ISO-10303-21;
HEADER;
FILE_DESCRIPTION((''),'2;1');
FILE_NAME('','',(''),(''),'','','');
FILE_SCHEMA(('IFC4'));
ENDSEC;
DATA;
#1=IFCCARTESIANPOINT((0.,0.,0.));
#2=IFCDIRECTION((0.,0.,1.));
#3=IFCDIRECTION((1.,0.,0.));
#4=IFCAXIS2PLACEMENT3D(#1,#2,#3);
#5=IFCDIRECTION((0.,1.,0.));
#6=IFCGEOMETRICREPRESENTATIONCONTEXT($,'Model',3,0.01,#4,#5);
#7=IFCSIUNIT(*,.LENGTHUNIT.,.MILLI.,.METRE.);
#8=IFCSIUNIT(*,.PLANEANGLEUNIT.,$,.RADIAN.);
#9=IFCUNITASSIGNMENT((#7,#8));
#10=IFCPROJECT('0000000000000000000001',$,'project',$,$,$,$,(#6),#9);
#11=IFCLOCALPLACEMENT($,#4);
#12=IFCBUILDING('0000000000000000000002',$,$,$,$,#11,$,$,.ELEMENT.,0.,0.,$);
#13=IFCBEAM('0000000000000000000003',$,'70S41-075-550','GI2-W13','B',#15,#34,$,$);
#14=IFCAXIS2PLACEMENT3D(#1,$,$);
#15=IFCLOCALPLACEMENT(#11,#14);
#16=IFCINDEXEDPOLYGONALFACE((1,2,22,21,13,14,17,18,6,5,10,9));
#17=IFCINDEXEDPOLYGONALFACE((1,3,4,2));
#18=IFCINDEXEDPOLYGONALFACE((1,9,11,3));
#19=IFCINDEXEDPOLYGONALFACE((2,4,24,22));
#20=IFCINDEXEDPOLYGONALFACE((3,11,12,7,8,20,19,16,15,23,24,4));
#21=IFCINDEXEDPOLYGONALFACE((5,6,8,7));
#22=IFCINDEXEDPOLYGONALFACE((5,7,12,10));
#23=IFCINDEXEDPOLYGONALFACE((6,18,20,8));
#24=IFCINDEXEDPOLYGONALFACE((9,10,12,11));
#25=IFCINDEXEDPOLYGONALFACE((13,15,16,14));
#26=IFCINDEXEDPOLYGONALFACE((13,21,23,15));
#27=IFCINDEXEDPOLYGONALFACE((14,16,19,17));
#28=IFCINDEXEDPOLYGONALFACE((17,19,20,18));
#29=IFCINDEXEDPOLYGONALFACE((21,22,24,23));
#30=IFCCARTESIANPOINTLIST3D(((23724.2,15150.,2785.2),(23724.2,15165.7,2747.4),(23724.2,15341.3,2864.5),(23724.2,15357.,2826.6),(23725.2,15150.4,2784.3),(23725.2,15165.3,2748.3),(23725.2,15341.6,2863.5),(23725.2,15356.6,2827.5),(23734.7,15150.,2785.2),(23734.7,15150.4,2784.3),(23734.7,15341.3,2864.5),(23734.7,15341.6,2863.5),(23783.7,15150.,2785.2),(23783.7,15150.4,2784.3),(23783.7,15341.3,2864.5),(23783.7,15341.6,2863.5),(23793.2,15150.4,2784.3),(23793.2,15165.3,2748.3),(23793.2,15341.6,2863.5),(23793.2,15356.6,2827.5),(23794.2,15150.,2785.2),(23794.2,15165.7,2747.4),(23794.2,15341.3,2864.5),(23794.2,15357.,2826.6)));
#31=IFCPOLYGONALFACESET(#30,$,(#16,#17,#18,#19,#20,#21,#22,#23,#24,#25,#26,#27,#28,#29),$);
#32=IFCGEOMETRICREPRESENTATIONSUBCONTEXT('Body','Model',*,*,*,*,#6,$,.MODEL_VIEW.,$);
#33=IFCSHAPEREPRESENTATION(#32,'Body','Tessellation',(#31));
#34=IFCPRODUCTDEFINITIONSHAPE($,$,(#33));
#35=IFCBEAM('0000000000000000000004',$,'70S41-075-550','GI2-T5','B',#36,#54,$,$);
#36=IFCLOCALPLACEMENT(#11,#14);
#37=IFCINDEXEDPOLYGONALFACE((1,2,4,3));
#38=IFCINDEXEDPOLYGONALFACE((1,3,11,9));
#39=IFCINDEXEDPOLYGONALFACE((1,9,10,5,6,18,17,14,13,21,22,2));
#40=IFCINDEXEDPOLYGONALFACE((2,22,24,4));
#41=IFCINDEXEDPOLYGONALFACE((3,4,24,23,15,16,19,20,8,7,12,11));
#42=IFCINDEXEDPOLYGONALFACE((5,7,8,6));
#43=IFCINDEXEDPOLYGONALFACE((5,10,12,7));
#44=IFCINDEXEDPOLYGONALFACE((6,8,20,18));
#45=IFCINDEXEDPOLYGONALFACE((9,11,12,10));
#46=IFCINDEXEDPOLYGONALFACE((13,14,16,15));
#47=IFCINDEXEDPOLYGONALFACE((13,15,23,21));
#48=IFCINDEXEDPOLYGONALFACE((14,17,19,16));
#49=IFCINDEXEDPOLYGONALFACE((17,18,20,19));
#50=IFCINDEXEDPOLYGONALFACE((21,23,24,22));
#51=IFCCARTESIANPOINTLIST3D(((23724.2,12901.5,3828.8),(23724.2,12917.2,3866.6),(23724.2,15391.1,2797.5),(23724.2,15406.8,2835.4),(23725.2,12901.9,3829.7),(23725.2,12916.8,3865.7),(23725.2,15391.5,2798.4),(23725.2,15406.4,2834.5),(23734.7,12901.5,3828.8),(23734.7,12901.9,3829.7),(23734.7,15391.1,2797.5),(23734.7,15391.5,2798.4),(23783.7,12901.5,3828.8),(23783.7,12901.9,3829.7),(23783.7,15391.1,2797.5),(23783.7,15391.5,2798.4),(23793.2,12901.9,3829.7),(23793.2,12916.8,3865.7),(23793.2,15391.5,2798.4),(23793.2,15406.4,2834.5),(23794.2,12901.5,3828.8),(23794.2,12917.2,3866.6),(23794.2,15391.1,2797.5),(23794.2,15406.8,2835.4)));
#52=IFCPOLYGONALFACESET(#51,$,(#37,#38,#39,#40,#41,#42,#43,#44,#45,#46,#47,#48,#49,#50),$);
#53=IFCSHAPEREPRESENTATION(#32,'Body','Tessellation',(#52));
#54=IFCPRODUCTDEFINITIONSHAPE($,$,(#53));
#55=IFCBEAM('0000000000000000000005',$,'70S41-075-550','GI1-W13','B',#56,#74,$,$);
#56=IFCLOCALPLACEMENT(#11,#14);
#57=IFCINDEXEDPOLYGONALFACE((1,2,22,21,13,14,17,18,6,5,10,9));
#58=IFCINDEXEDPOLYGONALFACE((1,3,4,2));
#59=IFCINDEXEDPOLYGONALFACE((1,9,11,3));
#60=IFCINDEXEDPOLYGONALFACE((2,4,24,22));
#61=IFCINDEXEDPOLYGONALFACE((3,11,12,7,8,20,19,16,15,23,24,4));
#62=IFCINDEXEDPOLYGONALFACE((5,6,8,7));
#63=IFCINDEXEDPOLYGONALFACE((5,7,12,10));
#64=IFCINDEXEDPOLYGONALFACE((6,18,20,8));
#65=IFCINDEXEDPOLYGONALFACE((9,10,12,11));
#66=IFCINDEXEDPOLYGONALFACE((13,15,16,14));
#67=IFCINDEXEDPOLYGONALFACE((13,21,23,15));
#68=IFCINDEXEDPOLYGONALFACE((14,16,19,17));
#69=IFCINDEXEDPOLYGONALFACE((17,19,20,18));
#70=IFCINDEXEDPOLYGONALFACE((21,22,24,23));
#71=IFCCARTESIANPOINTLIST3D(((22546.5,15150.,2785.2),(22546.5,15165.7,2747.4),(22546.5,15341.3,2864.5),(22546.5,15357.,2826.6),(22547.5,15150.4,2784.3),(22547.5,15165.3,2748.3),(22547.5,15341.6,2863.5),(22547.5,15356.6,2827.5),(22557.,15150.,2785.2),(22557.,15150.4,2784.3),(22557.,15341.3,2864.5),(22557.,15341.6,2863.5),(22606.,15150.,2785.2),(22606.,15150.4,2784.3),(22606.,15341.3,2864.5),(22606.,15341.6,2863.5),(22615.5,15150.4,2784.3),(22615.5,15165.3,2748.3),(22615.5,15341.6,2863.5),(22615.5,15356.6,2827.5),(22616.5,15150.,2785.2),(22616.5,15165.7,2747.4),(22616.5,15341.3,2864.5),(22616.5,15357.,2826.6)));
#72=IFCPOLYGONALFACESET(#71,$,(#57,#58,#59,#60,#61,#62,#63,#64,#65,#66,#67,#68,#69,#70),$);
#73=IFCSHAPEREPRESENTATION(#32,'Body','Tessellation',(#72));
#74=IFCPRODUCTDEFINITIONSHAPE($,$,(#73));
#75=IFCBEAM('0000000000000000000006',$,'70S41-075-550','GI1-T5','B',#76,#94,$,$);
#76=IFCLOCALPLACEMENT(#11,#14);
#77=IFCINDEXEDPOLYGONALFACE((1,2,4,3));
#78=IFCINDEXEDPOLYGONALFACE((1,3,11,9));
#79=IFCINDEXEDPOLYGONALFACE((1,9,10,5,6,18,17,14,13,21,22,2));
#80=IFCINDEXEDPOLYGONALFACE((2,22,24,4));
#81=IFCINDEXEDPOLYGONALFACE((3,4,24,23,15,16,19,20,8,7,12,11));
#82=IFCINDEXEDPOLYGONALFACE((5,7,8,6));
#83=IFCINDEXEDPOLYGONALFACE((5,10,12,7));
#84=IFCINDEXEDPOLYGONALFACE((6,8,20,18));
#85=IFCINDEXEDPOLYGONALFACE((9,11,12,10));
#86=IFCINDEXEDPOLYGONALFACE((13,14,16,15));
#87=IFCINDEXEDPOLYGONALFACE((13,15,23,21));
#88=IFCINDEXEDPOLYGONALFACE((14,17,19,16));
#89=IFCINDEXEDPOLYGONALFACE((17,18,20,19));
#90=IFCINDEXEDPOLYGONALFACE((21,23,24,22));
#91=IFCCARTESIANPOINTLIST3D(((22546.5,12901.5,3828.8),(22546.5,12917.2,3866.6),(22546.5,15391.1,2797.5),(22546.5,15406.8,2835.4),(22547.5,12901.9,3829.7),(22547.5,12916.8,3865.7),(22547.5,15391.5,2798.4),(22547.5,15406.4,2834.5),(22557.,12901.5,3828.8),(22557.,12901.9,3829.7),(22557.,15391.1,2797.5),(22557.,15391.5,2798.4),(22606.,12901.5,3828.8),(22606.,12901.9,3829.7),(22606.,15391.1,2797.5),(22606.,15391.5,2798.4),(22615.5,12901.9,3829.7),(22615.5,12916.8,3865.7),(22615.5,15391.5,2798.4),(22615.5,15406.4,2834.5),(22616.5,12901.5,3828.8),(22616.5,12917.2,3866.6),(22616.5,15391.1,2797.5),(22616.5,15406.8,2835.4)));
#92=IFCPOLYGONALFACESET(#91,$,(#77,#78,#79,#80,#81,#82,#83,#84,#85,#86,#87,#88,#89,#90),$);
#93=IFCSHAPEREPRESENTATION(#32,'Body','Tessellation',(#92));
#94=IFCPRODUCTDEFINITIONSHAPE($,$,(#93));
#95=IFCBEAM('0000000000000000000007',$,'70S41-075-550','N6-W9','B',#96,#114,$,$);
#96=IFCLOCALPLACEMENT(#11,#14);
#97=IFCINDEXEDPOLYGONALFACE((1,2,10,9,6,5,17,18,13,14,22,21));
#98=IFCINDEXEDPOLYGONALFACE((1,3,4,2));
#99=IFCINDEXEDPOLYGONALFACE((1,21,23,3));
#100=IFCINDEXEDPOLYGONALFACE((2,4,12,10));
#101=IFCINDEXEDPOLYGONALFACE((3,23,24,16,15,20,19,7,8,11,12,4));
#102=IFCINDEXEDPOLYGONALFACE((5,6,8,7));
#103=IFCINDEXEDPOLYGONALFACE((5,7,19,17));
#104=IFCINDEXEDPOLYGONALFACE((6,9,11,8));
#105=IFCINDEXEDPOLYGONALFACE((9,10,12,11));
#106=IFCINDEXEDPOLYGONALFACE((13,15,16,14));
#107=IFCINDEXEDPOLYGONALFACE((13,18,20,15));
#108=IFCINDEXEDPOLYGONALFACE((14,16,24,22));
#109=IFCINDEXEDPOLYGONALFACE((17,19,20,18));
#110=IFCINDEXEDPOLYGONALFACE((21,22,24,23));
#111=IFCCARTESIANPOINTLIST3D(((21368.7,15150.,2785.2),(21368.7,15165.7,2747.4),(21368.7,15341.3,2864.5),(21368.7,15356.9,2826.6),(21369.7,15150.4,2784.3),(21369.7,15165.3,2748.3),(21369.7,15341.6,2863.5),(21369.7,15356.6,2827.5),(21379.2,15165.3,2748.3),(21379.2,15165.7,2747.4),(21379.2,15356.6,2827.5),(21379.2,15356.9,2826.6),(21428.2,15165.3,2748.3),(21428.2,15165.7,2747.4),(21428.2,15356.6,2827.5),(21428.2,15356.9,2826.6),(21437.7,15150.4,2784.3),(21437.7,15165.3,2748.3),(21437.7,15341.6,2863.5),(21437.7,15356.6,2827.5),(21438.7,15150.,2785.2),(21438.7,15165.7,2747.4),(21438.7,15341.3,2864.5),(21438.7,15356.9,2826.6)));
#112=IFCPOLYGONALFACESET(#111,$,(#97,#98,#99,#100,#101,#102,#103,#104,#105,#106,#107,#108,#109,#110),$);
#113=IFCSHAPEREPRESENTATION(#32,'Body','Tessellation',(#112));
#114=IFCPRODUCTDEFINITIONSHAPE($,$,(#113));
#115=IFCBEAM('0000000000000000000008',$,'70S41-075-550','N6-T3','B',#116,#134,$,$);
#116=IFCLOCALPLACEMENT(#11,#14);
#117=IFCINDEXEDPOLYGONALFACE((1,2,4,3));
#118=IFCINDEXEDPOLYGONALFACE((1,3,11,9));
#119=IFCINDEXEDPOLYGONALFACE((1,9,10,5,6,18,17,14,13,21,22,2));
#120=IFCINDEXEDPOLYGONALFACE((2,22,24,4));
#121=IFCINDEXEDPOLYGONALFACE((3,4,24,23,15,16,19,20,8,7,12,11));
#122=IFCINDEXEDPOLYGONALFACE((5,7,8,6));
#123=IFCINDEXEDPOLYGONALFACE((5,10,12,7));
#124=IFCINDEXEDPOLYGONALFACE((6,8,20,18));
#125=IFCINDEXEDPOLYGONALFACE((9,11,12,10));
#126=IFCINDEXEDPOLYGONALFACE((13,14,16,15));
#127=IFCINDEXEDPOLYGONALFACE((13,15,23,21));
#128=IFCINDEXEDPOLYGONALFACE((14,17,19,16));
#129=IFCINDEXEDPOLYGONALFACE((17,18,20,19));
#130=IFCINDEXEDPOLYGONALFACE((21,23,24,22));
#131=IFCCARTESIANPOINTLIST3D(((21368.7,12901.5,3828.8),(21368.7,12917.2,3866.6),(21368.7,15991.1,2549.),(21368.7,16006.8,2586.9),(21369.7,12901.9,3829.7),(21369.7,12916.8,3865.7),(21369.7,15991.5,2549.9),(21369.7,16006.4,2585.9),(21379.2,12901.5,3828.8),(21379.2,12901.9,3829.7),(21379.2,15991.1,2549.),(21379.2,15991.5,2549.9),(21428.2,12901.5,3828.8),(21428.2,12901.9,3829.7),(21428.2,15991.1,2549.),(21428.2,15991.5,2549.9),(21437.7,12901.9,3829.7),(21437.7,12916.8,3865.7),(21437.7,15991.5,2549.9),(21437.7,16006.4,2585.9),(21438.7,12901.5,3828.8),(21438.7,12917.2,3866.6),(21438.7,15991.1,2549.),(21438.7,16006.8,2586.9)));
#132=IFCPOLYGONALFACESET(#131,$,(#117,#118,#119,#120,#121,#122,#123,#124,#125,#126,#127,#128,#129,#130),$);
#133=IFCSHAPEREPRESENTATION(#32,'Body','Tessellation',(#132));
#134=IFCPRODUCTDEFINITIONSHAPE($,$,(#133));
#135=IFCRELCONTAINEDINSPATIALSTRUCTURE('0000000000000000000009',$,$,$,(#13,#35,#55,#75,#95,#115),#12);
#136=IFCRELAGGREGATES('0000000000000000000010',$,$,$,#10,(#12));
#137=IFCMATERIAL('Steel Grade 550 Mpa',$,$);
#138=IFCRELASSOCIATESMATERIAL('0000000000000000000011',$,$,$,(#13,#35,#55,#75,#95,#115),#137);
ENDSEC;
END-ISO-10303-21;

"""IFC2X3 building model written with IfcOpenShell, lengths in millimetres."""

from ifc_helpers import new_model, si_unit, direction, frame, origin, origin_with_axes, origin_2d_with_axis, place, context, subcontext, project, spatial, c_section, extrude, source, transform, mapped, material, element, save


model = new_model("IFC2X3")

# Units and contexts
model_context = context("Model", 3, precision=0.01, world=origin_with_axes(), true_north=direction((0.0, 1.0, 0.0)))
body_context = subcontext(model_context, "Body", "Model", "MODEL_VIEW")
ifc_project = project(units=[si_unit("LENGTHUNIT", "METRE", prefix="MILLI"), si_unit("PLANEANGLEUNIT", "RADIAN")], contexts=[model_context])

# Building
building_placement = place(None, origin_with_axes())
building = spatial("IfcBuilding", under=ifc_project, at=building_placement, CompositionType="ELEMENT", ElevationOfRefHeight=0.0, ElevationOfTerrain=0.0)

# Shared definitions
ifc_material = material(Name="Steel Grade 550 Mpa")

# Beams
shared_shape_1 = source(origin(), body_context, "Body", "SweptSolid", [
    extrude(c_section(Depth=70.0, Width=41.0, WallThickness=1.0, Girth=10.5, at=origin_2d_with_axis()), origin_with_axes(), (0.0, 0.0, 1.0), 207.0),
])
beam_1_placement = place(None, frame((23759.2, 15157.9, 2766.3), z_axis=(-0.000003, 0.923831, 0.3828), x_axis=(0.000001, -0.3828, 0.923831)))
element("IfcBeam", 1, at=beam_1_placement, inside=building, material=ifc_material, Name="70S41-075-550", Description="GI2-W13", ObjectType="B", context=body_context, shape_type="MappedRepresentation", body=[
    mapped(shared_shape_1, transform((0.0, 0.0, 0.0), scale=1.0)),
])
shared_shape_2 = source(origin(), body_context, "Body", "SweptSolid", [
    extrude(c_section(Depth=70.0, Width=41.0, WallThickness=1.0, Girth=10.5, at=origin_2d_with_axis()), origin_with_axes(), (0.0, 0.0, 1.0), 2694.7),
])
beam_2_placement = place(None, frame((23759.2, 15399.0, 2816.5), z_axis=(0.000003, -0.92388, 0.382683), x_axis=(0.000001, -0.382683, -0.92388)))
element("IfcBeam", 2, at=beam_2_placement, inside=building, material=ifc_material, Name="70S41-075-550", Description="GI2-T5", ObjectType="B", context=body_context, shape_type="MappedRepresentation", body=[
    mapped(shared_shape_2, transform((0.0, 0.0, 0.0), scale=1.0)),
])
shared_shape_3 = source(origin(), body_context, "Body", "SweptSolid", [
    extrude(c_section(Depth=70.0, Width=41.0, WallThickness=1.0, Girth=10.5, at=origin_2d_with_axis()), origin_with_axes(), (0.0, 0.0, 1.0), 207.0),
])
beam_3_placement = place(None, frame((22581.5, 15157.9, 2766.3), z_axis=(-0.000003, 0.923831, 0.3828), x_axis=(0.000001, -0.3828, 0.923831)))
element("IfcBeam", 3, at=beam_3_placement, inside=building, material=ifc_material, Name="70S41-075-550", Description="GI1-W13", ObjectType="B", context=body_context, shape_type="MappedRepresentation", body=[
    mapped(shared_shape_3, transform((0.0, 0.0, 0.0), scale=1.0)),
])
shared_shape_4 = source(origin(), body_context, "Body", "SweptSolid", [
    extrude(c_section(Depth=70.0, Width=41.0, WallThickness=1.0, Girth=10.5, at=origin_2d_with_axis()), origin_with_axes(), (0.0, 0.0, 1.0), 2694.7),
])
beam_4_placement = place(None, frame((22581.5, 15398.9, 2816.5), z_axis=(0.000003, -0.92388, 0.382683), x_axis=(0.000001, -0.382683, -0.92388)))
element("IfcBeam", 4, at=beam_4_placement, inside=building, material=ifc_material, Name="70S41-075-550", Description="GI1-T5", ObjectType="B", context=body_context, shape_type="MappedRepresentation", body=[
    mapped(shared_shape_4, transform((0.0, 0.0, 0.0), scale=1.0)),
])
shared_shape_5 = source(origin(), body_context, "Body", "SweptSolid", [
    extrude(c_section(Depth=70.0, Width=41.0, WallThickness=1.0, Girth=10.5, at=origin_2d_with_axis()), origin_with_axes(), (0.0, 0.0, 1.0), 207.0),
])
beam_5_placement = place(None, frame((21403.7, 15349.1, 2845.5), z_axis=(0.000003, -0.923831, -0.3828), x_axis=(-0.000001, 0.3828, -0.923831)))
element("IfcBeam", 5, at=beam_5_placement, inside=building, material=ifc_material, Name="70S41-075-550", Description="N6-W9", ObjectType="B", context=body_context, shape_type="MappedRepresentation", body=[
    mapped(shared_shape_5, transform((0.0, 0.0, 0.0), scale=1.0)),
])
shared_shape_6 = source(origin(), body_context, "Body", "SweptSolid", [
    extrude(c_section(Depth=70.0, Width=41.0, WallThickness=1.0, Girth=10.5, at=origin_2d_with_axis()), origin_with_axes(), (0.0, 0.0, 1.0), 3344.2),
])
beam_6_placement = place(None, frame((21403.7, 15998.9, 2567.9), z_axis=(0.000003, -0.92388, 0.382683), x_axis=(0.000001, -0.382683, -0.92388)))
element("IfcBeam", 6, at=beam_6_placement, inside=building, material=ifc_material, Name="70S41-075-550", Description="N6-T3", ObjectType="B", context=body_context, shape_type="MappedRepresentation", body=[
    mapped(shared_shape_6, transform((0.0, 0.0, 0.0), scale=1.0)),
])

save(model, "model.ifc")
